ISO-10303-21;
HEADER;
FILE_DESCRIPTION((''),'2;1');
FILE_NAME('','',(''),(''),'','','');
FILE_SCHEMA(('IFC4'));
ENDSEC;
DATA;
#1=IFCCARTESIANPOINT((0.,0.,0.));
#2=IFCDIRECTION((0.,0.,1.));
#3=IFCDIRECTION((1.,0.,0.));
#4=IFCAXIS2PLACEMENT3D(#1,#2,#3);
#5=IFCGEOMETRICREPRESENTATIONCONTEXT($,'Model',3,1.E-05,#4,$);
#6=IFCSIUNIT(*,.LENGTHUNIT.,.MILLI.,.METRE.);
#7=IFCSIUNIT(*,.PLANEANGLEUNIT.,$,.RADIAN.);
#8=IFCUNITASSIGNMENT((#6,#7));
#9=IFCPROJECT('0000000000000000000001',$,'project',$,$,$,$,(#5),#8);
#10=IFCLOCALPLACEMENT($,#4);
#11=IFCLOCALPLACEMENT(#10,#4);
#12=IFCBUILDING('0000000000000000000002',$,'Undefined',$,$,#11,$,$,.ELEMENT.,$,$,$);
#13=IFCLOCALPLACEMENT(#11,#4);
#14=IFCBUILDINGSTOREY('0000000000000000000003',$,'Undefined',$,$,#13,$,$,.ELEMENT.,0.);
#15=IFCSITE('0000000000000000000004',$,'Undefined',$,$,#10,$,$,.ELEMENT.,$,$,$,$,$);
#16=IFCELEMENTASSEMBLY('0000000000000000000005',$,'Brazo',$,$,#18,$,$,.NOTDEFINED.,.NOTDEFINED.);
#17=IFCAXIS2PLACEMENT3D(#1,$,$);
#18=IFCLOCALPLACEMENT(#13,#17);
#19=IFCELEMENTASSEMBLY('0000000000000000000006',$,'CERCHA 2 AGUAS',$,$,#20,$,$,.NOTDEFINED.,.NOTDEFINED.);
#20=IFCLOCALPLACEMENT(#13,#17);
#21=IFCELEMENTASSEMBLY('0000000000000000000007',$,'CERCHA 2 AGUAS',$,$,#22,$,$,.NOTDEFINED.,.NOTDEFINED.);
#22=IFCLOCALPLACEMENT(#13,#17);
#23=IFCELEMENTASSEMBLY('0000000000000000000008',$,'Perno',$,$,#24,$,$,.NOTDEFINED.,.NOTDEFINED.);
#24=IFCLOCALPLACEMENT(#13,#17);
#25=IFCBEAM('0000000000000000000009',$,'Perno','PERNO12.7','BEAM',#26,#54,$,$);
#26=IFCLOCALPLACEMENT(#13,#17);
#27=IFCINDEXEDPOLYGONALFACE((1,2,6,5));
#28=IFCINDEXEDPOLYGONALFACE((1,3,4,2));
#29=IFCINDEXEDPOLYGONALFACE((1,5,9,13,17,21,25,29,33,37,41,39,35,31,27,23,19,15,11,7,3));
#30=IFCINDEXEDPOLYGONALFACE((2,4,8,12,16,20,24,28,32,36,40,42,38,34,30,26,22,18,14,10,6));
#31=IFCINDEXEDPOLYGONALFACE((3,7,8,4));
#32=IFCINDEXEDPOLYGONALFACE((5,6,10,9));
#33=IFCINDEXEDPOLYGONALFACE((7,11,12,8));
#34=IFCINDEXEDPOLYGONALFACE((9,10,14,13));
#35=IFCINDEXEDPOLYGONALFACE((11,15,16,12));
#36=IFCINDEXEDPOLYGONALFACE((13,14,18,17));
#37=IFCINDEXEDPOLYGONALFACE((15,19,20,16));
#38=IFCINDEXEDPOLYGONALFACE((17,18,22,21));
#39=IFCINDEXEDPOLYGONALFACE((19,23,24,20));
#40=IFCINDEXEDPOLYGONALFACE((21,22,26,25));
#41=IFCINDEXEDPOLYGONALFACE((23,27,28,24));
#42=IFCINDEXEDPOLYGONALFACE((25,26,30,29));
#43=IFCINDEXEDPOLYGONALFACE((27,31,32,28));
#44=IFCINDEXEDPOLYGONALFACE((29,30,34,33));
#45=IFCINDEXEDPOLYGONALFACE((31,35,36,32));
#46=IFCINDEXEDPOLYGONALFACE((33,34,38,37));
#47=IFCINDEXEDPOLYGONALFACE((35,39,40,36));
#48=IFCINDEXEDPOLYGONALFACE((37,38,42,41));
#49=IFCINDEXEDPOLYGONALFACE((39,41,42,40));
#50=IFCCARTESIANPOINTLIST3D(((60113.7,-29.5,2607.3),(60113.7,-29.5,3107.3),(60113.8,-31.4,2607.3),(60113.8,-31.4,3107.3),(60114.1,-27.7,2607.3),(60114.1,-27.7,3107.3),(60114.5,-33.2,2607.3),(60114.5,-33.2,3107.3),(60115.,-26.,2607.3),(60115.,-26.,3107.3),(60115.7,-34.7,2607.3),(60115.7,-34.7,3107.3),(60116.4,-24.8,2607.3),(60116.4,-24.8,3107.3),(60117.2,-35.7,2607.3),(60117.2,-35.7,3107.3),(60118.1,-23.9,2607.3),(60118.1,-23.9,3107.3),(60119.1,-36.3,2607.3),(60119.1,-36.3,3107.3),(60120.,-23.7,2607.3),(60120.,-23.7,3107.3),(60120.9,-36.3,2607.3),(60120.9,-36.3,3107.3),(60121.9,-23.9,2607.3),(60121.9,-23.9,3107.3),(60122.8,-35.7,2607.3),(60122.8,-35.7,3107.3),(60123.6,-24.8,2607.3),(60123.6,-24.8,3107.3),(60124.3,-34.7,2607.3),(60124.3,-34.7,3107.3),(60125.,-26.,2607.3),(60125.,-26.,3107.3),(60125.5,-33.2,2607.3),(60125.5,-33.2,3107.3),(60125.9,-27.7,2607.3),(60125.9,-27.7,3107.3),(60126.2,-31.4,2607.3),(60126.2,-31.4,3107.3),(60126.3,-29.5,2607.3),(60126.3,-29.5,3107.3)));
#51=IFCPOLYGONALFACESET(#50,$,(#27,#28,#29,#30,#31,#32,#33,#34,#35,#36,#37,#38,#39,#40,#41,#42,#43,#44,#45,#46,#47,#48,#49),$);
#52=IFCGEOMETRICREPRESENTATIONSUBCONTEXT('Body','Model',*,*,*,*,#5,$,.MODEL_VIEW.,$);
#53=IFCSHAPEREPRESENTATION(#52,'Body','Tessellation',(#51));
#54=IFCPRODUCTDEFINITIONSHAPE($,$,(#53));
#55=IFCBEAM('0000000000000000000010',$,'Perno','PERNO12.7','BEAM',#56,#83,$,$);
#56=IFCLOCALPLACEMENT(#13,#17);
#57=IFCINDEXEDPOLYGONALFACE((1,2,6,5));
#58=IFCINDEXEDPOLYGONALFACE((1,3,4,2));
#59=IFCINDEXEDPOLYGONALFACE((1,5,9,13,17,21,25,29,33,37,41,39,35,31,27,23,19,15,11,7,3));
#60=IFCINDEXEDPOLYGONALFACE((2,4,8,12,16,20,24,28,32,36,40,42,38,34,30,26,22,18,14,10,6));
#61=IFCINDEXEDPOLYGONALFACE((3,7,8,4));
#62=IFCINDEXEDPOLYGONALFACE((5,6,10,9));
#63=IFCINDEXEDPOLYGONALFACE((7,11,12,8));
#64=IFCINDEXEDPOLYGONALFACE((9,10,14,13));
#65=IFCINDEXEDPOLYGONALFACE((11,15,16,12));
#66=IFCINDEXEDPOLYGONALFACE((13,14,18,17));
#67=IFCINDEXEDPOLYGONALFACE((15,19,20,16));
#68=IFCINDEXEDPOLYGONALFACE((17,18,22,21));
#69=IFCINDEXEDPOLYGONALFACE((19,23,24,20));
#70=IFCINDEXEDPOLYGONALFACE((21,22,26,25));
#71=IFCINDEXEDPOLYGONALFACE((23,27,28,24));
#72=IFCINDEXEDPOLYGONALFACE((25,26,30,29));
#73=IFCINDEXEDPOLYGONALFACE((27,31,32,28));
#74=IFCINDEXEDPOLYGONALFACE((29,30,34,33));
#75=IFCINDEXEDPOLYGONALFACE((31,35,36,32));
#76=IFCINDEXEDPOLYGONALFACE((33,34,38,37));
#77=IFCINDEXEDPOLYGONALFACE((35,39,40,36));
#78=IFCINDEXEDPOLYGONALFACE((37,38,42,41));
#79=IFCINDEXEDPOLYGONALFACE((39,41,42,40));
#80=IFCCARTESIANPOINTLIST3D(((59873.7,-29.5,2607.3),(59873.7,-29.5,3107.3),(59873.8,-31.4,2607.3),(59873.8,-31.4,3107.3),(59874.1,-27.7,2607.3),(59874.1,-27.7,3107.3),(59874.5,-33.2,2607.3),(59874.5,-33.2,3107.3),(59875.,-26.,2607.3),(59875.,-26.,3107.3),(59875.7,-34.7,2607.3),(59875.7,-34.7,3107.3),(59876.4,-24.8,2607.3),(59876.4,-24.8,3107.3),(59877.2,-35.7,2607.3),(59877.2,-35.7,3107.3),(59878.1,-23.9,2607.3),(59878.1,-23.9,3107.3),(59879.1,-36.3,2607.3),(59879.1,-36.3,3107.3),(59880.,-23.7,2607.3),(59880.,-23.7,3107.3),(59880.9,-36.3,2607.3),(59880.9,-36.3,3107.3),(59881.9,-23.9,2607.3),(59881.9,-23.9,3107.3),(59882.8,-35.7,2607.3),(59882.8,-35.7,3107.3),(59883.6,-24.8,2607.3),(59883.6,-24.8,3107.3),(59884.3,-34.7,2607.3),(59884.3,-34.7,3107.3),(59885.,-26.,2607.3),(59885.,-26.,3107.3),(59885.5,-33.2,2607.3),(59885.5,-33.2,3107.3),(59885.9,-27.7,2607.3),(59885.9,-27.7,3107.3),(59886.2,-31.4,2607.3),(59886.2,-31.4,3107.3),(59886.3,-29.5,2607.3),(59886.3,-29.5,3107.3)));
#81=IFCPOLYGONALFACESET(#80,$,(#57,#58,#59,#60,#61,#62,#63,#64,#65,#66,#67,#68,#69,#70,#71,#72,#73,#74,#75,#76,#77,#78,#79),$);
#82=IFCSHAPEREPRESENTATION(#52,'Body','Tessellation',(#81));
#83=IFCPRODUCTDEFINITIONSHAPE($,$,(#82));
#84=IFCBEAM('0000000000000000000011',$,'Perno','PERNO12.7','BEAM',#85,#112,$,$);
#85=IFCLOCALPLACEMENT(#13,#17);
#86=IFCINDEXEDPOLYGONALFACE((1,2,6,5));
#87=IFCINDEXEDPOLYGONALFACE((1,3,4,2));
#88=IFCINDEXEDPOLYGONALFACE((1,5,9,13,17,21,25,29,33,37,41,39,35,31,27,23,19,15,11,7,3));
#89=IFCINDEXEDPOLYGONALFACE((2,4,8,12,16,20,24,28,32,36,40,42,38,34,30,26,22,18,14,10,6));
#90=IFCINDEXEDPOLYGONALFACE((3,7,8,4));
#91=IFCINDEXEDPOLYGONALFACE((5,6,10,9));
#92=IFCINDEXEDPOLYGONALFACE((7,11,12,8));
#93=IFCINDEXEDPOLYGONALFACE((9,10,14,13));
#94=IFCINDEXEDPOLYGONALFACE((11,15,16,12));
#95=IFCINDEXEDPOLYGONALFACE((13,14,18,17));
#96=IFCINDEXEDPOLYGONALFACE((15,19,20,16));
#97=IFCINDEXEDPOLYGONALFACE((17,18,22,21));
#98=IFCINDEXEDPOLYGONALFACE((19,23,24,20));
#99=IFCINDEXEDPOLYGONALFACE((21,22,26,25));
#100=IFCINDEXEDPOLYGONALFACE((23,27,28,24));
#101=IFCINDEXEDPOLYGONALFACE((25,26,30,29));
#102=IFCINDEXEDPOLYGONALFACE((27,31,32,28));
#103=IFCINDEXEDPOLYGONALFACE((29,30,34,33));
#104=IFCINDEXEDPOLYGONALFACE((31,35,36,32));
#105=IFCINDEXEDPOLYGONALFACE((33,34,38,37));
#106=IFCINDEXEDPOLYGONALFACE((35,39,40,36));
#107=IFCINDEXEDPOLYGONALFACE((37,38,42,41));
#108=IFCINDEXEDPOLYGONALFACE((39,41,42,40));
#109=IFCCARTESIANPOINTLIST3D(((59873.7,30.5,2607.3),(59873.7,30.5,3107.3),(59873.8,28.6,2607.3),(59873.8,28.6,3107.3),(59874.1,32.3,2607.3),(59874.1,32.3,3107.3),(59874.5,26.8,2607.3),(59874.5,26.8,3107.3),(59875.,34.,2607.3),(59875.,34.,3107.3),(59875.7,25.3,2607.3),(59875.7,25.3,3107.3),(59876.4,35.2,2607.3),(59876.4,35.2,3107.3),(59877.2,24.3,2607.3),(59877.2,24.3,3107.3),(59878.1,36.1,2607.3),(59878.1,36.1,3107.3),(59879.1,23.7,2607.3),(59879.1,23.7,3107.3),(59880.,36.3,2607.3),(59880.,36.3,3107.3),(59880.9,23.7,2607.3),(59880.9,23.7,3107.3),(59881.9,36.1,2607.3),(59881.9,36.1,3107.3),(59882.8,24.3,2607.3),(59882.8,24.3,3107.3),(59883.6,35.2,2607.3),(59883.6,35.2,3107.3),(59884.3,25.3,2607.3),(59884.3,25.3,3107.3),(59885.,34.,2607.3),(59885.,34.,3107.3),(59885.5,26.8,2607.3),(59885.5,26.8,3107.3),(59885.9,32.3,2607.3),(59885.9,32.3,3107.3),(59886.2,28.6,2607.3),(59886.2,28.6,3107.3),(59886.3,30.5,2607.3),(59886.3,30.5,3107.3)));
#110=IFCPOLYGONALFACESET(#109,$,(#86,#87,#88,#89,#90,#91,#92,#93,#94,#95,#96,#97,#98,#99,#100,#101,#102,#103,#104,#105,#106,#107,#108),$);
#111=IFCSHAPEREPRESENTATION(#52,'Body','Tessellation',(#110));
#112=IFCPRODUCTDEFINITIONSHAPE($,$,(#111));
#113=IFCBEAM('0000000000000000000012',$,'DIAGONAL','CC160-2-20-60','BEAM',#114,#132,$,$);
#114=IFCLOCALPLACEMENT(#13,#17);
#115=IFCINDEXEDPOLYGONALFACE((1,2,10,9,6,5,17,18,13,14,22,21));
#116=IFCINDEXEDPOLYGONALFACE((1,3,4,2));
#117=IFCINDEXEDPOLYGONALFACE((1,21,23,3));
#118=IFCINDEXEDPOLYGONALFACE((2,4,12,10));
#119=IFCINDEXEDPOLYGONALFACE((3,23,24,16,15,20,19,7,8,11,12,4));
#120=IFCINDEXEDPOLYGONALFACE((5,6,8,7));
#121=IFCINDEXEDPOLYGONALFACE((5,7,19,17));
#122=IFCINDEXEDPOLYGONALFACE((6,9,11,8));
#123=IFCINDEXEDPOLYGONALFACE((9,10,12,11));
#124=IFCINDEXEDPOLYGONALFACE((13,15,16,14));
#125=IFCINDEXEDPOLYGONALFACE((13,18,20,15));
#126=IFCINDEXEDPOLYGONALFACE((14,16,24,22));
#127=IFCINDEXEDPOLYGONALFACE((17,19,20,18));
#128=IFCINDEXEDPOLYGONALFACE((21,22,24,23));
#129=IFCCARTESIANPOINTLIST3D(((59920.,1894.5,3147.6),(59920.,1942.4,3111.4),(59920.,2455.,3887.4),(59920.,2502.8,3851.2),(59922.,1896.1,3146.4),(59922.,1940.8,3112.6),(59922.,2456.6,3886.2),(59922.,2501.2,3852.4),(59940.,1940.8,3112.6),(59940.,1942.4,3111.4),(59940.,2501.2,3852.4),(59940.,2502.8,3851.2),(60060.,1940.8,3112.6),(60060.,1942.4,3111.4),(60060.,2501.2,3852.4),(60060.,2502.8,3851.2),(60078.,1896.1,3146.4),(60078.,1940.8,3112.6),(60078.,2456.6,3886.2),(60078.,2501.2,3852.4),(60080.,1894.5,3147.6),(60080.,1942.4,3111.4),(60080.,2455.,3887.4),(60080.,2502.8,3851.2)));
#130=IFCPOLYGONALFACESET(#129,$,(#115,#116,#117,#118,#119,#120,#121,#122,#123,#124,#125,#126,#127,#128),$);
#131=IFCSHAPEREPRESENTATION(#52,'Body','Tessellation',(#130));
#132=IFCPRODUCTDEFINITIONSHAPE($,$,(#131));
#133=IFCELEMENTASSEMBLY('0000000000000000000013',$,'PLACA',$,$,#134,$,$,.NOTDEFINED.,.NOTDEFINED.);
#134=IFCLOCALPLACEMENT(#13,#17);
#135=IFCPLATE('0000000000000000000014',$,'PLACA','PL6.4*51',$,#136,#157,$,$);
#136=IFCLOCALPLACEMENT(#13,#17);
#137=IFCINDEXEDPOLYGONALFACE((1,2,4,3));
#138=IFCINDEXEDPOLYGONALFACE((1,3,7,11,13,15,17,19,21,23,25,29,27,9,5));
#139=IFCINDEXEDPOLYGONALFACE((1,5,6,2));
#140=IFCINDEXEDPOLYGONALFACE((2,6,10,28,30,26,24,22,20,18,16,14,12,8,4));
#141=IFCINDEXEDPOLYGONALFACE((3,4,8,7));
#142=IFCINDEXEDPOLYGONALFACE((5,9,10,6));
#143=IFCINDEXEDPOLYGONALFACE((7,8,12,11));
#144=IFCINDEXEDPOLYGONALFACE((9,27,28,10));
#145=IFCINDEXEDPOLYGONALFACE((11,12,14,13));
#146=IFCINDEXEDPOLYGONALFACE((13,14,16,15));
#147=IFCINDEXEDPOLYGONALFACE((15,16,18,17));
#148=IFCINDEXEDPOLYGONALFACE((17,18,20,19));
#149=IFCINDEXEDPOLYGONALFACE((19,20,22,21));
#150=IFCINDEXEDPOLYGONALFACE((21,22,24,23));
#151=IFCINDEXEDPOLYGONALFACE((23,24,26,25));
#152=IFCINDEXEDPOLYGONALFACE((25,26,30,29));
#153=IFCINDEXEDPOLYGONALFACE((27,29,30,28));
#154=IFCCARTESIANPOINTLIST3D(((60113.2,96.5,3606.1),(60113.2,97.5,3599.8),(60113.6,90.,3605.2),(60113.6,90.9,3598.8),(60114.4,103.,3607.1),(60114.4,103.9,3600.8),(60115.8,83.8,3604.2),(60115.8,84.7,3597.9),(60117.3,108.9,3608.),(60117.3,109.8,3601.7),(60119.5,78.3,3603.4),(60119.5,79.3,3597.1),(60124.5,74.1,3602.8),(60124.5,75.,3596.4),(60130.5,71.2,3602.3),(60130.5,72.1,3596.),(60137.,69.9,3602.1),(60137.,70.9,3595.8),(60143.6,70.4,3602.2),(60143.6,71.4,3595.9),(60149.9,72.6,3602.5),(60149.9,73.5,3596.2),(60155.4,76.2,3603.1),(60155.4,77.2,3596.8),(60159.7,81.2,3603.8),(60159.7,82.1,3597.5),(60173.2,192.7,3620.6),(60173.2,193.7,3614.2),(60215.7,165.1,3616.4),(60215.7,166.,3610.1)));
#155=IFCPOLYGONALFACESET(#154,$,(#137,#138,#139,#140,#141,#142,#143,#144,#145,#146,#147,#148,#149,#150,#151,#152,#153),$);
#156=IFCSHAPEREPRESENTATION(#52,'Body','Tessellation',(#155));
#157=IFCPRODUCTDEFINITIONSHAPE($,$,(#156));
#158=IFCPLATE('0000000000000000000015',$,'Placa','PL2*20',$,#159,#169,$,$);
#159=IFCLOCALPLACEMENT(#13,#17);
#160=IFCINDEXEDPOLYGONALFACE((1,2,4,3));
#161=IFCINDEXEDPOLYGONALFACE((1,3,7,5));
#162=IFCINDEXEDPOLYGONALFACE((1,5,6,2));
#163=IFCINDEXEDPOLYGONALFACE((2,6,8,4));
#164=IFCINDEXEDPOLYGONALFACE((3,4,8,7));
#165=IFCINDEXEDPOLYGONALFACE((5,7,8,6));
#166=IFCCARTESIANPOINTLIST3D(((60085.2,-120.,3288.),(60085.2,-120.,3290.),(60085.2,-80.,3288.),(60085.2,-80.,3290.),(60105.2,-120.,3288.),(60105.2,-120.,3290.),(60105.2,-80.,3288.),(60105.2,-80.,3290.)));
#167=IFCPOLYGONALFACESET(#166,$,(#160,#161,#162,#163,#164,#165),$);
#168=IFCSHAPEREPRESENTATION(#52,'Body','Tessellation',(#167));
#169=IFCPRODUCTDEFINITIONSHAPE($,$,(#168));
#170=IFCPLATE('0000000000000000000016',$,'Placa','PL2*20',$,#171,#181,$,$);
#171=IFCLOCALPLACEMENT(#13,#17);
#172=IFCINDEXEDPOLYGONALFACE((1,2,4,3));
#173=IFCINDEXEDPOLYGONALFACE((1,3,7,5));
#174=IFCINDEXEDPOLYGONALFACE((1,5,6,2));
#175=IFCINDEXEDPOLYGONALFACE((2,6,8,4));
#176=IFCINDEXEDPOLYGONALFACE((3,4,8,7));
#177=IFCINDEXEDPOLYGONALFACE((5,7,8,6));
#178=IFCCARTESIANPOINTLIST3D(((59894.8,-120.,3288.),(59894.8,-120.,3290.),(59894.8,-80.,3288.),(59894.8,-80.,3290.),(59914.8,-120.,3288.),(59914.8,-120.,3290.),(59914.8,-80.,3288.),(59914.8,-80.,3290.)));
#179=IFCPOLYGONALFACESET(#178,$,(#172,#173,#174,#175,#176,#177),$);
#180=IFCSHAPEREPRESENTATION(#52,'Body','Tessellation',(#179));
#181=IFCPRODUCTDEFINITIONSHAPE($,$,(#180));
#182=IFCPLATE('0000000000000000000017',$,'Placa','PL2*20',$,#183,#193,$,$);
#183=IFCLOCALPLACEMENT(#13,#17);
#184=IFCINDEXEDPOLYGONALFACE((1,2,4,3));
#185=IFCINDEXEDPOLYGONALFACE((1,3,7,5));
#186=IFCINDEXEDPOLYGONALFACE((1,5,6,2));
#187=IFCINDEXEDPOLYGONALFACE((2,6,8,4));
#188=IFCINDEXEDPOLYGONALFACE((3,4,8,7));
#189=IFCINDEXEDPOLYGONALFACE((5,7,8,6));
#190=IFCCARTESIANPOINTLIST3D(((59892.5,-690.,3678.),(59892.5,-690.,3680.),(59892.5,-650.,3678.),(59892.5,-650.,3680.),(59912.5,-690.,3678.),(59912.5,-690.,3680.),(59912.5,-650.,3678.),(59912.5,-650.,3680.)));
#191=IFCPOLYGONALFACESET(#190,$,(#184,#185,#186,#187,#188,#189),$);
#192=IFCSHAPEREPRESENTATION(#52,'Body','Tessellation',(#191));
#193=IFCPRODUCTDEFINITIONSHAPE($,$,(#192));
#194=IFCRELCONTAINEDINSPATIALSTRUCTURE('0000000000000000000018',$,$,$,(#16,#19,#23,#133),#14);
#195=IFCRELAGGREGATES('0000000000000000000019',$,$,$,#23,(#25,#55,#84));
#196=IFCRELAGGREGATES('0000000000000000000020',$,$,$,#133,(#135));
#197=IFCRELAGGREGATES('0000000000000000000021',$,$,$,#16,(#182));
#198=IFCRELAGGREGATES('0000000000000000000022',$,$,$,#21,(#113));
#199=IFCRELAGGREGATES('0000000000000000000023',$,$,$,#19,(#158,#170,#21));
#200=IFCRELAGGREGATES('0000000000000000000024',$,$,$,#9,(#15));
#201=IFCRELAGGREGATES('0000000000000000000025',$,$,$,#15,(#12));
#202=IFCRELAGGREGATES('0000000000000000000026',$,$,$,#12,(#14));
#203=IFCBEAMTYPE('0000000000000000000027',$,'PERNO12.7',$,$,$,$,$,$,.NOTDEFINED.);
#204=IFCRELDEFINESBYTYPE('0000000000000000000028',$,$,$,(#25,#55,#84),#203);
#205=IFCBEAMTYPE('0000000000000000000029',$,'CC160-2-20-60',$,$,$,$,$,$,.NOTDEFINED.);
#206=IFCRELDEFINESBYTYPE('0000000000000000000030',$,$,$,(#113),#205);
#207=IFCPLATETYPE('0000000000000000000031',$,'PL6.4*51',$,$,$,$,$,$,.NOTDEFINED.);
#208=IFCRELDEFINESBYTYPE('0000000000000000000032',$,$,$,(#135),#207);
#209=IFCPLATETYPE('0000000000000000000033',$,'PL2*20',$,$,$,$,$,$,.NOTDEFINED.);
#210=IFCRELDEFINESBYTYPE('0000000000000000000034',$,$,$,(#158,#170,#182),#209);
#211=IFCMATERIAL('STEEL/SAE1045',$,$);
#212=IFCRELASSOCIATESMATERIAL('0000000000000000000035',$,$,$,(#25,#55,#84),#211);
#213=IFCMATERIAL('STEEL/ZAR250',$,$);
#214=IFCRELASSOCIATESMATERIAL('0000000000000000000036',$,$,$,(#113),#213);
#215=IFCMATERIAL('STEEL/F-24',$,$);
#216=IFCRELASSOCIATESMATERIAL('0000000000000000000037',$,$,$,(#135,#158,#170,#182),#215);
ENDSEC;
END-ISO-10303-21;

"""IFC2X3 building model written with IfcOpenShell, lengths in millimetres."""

from ifc_helpers import new_model, si_unit, frame, frame_2d, origin_with_axes, origin_2d_with_axis, place, context, subcontext, project, spatial, polyline, circle_curve, parameter, trimmed, segment, composite_curve, circle, c_section, outline, extrude, material, type_object, element, aggregate, save


model = new_model("IFC2X3")

# Units and contexts
model_context = context("Model", 3, precision=1e-05, world=origin_with_axes())
body_context = subcontext(model_context, "Body", "Model", "MODEL_VIEW")
ifc_project = project(units=[si_unit("LENGTHUNIT", "METRE", prefix="MILLI"), si_unit("PLANEANGLEUNIT", "RADIAN")], contexts=[model_context])

# Site, building, storey
site_placement = place(None, origin_with_axes())
site = spatial("IfcSite", under=ifc_project, at=site_placement, Name="Undefined", CompositionType="ELEMENT")
building_placement = place(site_placement, origin_with_axes())
building = spatial("IfcBuilding", under=site, at=building_placement, Name="Undefined", CompositionType="ELEMENT")
storey_placement = place(building_placement, origin_with_axes())
storey = spatial("IfcBuildingStorey", under=building, at=storey_placement, Name="Undefined", CompositionType="ELEMENT", Elevation=0.0)

# Element assembly
assembly_1_placement = place(storey_placement, origin_with_axes())
assembly_1 = element("IfcElementAssembly", 1, at=assembly_1_placement, inside=storey, Name="Brazo", AssemblyPlace="NOTDEFINED", PredefinedType="NOTDEFINED")
ifc_material_1 = material(Name="STEEL/ZAR250")

# Element assemblies
assembly_2_placement = place(storey_placement, origin_with_axes())
assembly_2 = element("IfcElementAssembly", 2, at=assembly_2_placement, inside=storey, Name="CERCHA 2 AGUAS", AssemblyPlace="NOTDEFINED", PredefinedType="NOTDEFINED")
assembly_3_placement = place(assembly_2_placement, origin_with_axes())
assembly_3 = element("IfcElementAssembly", 3, at=assembly_3_placement, Name="CERCHA 2 AGUAS", AssemblyPlace="NOTDEFINED", PredefinedType="NOTDEFINED")

# Element assembly, beams
assembly_4_placement = place(storey_placement, origin_with_axes())
assembly_4 = element("IfcElementAssembly", 4, at=assembly_4_placement, inside=storey, Name="Perno", AssemblyPlace="NOTDEFINED", PredefinedType="NOTDEFINED")
ifc_material_2 = material(Name="STEEL/SAE1045")
beam_type_1 = type_object("IfcBeamType", Name="PERNO12.7", PredefinedType="NOTDEFINED")
beam_1_placement = place(assembly_4_placement, frame((60120.0, -30.0, 3107.3), z_axis=(-1.0, 0.0, 0.0), x_axis=(0.0, 0.0, -1.0)))
beam_1 = element("IfcBeam", 5, at=beam_1_placement, type_object=beam_type_1, material=ifc_material_2, Name="Perno", Description="PERNO12.7", ObjectType="BEAM", context=body_context, shape_type="SweptSolid", body=[
    extrude(circle(Radius=6.3, at=origin_2d_with_axis()), frame((500.0, 0.0, 0.0), z_axis=(-1.0, 0.0, 0.0), x_axis=(0.0, -1.0, 0.0)), (0.0, 0.0, 1.0), 500.0),
])
beam_2_placement = place(assembly_4_placement, frame((59880.0, -30.0, 3107.3), z_axis=(-1.0, 0.0, 0.0), x_axis=(0.0, 0.0, -1.0)))
beam_2 = element("IfcBeam", 6, at=beam_2_placement, type_object=beam_type_1, material=ifc_material_2, Name="Perno", Description="PERNO12.7", ObjectType="BEAM", context=body_context, shape_type="SweptSolid", body=[
    extrude(circle(Radius=6.3, at=origin_2d_with_axis()), frame((500.0, 0.0, 0.0), z_axis=(-1.0, 0.0, 0.0), x_axis=(0.0, -1.0, 0.0)), (0.0, 0.0, 1.0), 500.0),
])
beam_3_placement = place(assembly_4_placement, frame((59880.0, 30.0, 3107.3), z_axis=(-1.0, 0.0, 0.0), x_axis=(0.0, 0.0, -1.0)))
beam_3 = element("IfcBeam", 7, at=beam_3_placement, type_object=beam_type_1, material=ifc_material_2, Name="Perno", Description="PERNO12.7", ObjectType="BEAM", context=body_context, shape_type="SweptSolid", body=[
    extrude(circle(Radius=6.3, at=origin_2d_with_axis()), frame((500.0, 0.0, 0.0), z_axis=(-1.0, 0.0, 0.0), x_axis=(0.0, -1.0, 0.0)), (0.0, 0.0, 1.0), 500.0),
])
aggregate(assembly_4, [beam_1, beam_2, beam_3])

# Beam
beam_type_2 = type_object("IfcBeamType", Name="CC160-2-20-60", PredefinedType="NOTDEFINED")
beam_4_placement = place(assembly_3_placement, frame((60000.0, 1918.5, 3129.5), z_axis=(1.0, 0.0, 0.0), x_axis=(0.0, 0.603858, 0.797092)))
beam_4 = element("IfcBeam", 8, at=beam_4_placement, type_object=beam_type_2, material=ifc_material_1, Name="DIAGONAL", Description="CC160-2-20-60", ObjectType="BEAM", context=body_context, shape_type="SweptSolid", body=[
    extrude(c_section(Depth=160.0, Width=60.0, WallThickness=2.0, Girth=20.0, at=origin_2d_with_axis()), frame((928.1, 0.0, 0.0), z_axis=(-1.0, 0.0, 0.0), x_axis=(0.0, -1.0, 0.0)), (0.0, 0.0, 1.0), 928.1),
])

# Element assembly, plate
assembly_5_placement = place(storey_placement, origin_with_axes())
assembly_5 = element("IfcElementAssembly", 9, at=assembly_5_placement, inside=storey, Name="PLACA", AssemblyPlace="NOTDEFINED", PredefinedType="NOTDEFINED")
ifc_material_3 = material(Name="STEEL/F-24")
plate_type_1 = type_object("IfcPlateType", Name="PL6.4*51", PredefinedType="NOTDEFINED")
plate_1_placement = place(assembly_5_placement, frame((60103.3, 88.4, 3601.7), z_axis=(-0.00002, -0.148374, 0.988931), x_axis=(0.834881, -0.544341, -0.081653)))
plate_1 = element("IfcPlate", 10, at=plate_1_placement, type_object=plate_type_1, material=ifc_material_3, Name="PLACA", Description="PL6.4*51", context=body_context, shape_type="SweptSolid", body=[
    extrude(outline(composite_curve([segment(trimmed(circle_curve(frame_2d((25.4, 25.4), x_axis=(-1.0, 0.0)), 25.4), [parameter(0.0)], [parameter(1.570796)], True, "PARAMETER"), True, "CONTINUOUS"), segment(polyline([(25.4, 0.0), (25.4, 0.0)]), True, "CONTINUOUS"), segment(trimmed(circle_curve(frame_2d((25.4, 25.4), x_axis=(0.0, -1.0)), 25.4), [parameter(0.0)], [parameter(1.570797)], True, "PARAMETER"), True, "CONTINUOUS"), segment(polyline([(50.8, 25.4), (50.8, 127.0), (0.0, 127.0), (0.0, 25.4)]), True, "CONTINUOUS")], self_intersect=True)), frame((0.0, 0.0, -3.2), z_axis=(0.0, 0.0, 1.0), x_axis=(1.0, 0.0, 0.0)), (0.0, 0.0, 1.0), 6.4),
])
aggregate(assembly_5, [plate_1])

# Plates
plate_type_2 = type_object("IfcPlateType", Name="PL2*20", PredefinedType="NOTDEFINED")
plate_2_placement = place(assembly_2_placement, frame((60105.2, -120.0, 3289.0), z_axis=(0.0, -0.000121, 1.0), x_axis=(0.000085, 1.0, 0.000121)))
plate_2 = element("IfcPlate", 11, at=plate_2_placement, type_object=plate_type_2, material=ifc_material_3, Name="Placa", Description="PL2*20", context=body_context, shape_type="SweptSolid", body=[
    extrude(outline(polyline([(0.0, 0.0), (40.0, 0.0), (40.0, 20.0), (0.0, 20.0), (0.0, 0.0)])), frame((0.0, 0.0, -1.0), z_axis=(0.0, 0.0, 1.0), x_axis=(1.0, 0.0, 0.0)), (0.0, 0.0, 1.0), 2.0),
])
plate_3_placement = place(assembly_2_placement, frame((59914.8, -120.0, 3289.0), z_axis=(0.0, -0.000121, 1.0), x_axis=(0.000085, 1.0, 0.000121)))
plate_3 = element("IfcPlate", 12, at=plate_3_placement, type_object=plate_type_2, material=ifc_material_3, Name="Placa", Description="PL2*20", context=body_context, shape_type="SweptSolid", body=[
    extrude(outline(polyline([(0.0, 0.0), (40.0, 0.0), (40.0, 20.0), (0.0, 20.0), (0.0, 0.0)])), frame((0.0, 0.0, -1.0), z_axis=(0.0, 0.0, 1.0), x_axis=(1.0, 0.0, 0.0)), (0.0, 0.0, 1.0), 2.0),
])
plate_4_placement = place(assembly_1_placement, frame((59912.5, -690.0, 3679.0), z_axis=(0.0, -0.000121, 1.0), x_axis=(0.000085, 1.0, 0.000121)))
plate_4 = element("IfcPlate", 13, at=plate_4_placement, type_object=plate_type_2, material=ifc_material_3, Name="Placa", Description="PL2*20", context=body_context, shape_type="SweptSolid", body=[
    extrude(outline(polyline([(0.0, 0.0), (40.0, 0.0), (40.0, 20.0), (0.0, 20.0), (0.0, 0.0)])), frame((0.0, 0.0, -1.0), z_axis=(0.0, 0.0, 1.0), x_axis=(1.0, 0.0, 0.0)), (0.0, 0.0, 1.0), 2.0),
])
aggregate(assembly_1, [plate_4])

aggregate(assembly_3, [beam_4])

aggregate(assembly_2, [plate_2, plate_3, assembly_3])

save(model, "model.ifc")
